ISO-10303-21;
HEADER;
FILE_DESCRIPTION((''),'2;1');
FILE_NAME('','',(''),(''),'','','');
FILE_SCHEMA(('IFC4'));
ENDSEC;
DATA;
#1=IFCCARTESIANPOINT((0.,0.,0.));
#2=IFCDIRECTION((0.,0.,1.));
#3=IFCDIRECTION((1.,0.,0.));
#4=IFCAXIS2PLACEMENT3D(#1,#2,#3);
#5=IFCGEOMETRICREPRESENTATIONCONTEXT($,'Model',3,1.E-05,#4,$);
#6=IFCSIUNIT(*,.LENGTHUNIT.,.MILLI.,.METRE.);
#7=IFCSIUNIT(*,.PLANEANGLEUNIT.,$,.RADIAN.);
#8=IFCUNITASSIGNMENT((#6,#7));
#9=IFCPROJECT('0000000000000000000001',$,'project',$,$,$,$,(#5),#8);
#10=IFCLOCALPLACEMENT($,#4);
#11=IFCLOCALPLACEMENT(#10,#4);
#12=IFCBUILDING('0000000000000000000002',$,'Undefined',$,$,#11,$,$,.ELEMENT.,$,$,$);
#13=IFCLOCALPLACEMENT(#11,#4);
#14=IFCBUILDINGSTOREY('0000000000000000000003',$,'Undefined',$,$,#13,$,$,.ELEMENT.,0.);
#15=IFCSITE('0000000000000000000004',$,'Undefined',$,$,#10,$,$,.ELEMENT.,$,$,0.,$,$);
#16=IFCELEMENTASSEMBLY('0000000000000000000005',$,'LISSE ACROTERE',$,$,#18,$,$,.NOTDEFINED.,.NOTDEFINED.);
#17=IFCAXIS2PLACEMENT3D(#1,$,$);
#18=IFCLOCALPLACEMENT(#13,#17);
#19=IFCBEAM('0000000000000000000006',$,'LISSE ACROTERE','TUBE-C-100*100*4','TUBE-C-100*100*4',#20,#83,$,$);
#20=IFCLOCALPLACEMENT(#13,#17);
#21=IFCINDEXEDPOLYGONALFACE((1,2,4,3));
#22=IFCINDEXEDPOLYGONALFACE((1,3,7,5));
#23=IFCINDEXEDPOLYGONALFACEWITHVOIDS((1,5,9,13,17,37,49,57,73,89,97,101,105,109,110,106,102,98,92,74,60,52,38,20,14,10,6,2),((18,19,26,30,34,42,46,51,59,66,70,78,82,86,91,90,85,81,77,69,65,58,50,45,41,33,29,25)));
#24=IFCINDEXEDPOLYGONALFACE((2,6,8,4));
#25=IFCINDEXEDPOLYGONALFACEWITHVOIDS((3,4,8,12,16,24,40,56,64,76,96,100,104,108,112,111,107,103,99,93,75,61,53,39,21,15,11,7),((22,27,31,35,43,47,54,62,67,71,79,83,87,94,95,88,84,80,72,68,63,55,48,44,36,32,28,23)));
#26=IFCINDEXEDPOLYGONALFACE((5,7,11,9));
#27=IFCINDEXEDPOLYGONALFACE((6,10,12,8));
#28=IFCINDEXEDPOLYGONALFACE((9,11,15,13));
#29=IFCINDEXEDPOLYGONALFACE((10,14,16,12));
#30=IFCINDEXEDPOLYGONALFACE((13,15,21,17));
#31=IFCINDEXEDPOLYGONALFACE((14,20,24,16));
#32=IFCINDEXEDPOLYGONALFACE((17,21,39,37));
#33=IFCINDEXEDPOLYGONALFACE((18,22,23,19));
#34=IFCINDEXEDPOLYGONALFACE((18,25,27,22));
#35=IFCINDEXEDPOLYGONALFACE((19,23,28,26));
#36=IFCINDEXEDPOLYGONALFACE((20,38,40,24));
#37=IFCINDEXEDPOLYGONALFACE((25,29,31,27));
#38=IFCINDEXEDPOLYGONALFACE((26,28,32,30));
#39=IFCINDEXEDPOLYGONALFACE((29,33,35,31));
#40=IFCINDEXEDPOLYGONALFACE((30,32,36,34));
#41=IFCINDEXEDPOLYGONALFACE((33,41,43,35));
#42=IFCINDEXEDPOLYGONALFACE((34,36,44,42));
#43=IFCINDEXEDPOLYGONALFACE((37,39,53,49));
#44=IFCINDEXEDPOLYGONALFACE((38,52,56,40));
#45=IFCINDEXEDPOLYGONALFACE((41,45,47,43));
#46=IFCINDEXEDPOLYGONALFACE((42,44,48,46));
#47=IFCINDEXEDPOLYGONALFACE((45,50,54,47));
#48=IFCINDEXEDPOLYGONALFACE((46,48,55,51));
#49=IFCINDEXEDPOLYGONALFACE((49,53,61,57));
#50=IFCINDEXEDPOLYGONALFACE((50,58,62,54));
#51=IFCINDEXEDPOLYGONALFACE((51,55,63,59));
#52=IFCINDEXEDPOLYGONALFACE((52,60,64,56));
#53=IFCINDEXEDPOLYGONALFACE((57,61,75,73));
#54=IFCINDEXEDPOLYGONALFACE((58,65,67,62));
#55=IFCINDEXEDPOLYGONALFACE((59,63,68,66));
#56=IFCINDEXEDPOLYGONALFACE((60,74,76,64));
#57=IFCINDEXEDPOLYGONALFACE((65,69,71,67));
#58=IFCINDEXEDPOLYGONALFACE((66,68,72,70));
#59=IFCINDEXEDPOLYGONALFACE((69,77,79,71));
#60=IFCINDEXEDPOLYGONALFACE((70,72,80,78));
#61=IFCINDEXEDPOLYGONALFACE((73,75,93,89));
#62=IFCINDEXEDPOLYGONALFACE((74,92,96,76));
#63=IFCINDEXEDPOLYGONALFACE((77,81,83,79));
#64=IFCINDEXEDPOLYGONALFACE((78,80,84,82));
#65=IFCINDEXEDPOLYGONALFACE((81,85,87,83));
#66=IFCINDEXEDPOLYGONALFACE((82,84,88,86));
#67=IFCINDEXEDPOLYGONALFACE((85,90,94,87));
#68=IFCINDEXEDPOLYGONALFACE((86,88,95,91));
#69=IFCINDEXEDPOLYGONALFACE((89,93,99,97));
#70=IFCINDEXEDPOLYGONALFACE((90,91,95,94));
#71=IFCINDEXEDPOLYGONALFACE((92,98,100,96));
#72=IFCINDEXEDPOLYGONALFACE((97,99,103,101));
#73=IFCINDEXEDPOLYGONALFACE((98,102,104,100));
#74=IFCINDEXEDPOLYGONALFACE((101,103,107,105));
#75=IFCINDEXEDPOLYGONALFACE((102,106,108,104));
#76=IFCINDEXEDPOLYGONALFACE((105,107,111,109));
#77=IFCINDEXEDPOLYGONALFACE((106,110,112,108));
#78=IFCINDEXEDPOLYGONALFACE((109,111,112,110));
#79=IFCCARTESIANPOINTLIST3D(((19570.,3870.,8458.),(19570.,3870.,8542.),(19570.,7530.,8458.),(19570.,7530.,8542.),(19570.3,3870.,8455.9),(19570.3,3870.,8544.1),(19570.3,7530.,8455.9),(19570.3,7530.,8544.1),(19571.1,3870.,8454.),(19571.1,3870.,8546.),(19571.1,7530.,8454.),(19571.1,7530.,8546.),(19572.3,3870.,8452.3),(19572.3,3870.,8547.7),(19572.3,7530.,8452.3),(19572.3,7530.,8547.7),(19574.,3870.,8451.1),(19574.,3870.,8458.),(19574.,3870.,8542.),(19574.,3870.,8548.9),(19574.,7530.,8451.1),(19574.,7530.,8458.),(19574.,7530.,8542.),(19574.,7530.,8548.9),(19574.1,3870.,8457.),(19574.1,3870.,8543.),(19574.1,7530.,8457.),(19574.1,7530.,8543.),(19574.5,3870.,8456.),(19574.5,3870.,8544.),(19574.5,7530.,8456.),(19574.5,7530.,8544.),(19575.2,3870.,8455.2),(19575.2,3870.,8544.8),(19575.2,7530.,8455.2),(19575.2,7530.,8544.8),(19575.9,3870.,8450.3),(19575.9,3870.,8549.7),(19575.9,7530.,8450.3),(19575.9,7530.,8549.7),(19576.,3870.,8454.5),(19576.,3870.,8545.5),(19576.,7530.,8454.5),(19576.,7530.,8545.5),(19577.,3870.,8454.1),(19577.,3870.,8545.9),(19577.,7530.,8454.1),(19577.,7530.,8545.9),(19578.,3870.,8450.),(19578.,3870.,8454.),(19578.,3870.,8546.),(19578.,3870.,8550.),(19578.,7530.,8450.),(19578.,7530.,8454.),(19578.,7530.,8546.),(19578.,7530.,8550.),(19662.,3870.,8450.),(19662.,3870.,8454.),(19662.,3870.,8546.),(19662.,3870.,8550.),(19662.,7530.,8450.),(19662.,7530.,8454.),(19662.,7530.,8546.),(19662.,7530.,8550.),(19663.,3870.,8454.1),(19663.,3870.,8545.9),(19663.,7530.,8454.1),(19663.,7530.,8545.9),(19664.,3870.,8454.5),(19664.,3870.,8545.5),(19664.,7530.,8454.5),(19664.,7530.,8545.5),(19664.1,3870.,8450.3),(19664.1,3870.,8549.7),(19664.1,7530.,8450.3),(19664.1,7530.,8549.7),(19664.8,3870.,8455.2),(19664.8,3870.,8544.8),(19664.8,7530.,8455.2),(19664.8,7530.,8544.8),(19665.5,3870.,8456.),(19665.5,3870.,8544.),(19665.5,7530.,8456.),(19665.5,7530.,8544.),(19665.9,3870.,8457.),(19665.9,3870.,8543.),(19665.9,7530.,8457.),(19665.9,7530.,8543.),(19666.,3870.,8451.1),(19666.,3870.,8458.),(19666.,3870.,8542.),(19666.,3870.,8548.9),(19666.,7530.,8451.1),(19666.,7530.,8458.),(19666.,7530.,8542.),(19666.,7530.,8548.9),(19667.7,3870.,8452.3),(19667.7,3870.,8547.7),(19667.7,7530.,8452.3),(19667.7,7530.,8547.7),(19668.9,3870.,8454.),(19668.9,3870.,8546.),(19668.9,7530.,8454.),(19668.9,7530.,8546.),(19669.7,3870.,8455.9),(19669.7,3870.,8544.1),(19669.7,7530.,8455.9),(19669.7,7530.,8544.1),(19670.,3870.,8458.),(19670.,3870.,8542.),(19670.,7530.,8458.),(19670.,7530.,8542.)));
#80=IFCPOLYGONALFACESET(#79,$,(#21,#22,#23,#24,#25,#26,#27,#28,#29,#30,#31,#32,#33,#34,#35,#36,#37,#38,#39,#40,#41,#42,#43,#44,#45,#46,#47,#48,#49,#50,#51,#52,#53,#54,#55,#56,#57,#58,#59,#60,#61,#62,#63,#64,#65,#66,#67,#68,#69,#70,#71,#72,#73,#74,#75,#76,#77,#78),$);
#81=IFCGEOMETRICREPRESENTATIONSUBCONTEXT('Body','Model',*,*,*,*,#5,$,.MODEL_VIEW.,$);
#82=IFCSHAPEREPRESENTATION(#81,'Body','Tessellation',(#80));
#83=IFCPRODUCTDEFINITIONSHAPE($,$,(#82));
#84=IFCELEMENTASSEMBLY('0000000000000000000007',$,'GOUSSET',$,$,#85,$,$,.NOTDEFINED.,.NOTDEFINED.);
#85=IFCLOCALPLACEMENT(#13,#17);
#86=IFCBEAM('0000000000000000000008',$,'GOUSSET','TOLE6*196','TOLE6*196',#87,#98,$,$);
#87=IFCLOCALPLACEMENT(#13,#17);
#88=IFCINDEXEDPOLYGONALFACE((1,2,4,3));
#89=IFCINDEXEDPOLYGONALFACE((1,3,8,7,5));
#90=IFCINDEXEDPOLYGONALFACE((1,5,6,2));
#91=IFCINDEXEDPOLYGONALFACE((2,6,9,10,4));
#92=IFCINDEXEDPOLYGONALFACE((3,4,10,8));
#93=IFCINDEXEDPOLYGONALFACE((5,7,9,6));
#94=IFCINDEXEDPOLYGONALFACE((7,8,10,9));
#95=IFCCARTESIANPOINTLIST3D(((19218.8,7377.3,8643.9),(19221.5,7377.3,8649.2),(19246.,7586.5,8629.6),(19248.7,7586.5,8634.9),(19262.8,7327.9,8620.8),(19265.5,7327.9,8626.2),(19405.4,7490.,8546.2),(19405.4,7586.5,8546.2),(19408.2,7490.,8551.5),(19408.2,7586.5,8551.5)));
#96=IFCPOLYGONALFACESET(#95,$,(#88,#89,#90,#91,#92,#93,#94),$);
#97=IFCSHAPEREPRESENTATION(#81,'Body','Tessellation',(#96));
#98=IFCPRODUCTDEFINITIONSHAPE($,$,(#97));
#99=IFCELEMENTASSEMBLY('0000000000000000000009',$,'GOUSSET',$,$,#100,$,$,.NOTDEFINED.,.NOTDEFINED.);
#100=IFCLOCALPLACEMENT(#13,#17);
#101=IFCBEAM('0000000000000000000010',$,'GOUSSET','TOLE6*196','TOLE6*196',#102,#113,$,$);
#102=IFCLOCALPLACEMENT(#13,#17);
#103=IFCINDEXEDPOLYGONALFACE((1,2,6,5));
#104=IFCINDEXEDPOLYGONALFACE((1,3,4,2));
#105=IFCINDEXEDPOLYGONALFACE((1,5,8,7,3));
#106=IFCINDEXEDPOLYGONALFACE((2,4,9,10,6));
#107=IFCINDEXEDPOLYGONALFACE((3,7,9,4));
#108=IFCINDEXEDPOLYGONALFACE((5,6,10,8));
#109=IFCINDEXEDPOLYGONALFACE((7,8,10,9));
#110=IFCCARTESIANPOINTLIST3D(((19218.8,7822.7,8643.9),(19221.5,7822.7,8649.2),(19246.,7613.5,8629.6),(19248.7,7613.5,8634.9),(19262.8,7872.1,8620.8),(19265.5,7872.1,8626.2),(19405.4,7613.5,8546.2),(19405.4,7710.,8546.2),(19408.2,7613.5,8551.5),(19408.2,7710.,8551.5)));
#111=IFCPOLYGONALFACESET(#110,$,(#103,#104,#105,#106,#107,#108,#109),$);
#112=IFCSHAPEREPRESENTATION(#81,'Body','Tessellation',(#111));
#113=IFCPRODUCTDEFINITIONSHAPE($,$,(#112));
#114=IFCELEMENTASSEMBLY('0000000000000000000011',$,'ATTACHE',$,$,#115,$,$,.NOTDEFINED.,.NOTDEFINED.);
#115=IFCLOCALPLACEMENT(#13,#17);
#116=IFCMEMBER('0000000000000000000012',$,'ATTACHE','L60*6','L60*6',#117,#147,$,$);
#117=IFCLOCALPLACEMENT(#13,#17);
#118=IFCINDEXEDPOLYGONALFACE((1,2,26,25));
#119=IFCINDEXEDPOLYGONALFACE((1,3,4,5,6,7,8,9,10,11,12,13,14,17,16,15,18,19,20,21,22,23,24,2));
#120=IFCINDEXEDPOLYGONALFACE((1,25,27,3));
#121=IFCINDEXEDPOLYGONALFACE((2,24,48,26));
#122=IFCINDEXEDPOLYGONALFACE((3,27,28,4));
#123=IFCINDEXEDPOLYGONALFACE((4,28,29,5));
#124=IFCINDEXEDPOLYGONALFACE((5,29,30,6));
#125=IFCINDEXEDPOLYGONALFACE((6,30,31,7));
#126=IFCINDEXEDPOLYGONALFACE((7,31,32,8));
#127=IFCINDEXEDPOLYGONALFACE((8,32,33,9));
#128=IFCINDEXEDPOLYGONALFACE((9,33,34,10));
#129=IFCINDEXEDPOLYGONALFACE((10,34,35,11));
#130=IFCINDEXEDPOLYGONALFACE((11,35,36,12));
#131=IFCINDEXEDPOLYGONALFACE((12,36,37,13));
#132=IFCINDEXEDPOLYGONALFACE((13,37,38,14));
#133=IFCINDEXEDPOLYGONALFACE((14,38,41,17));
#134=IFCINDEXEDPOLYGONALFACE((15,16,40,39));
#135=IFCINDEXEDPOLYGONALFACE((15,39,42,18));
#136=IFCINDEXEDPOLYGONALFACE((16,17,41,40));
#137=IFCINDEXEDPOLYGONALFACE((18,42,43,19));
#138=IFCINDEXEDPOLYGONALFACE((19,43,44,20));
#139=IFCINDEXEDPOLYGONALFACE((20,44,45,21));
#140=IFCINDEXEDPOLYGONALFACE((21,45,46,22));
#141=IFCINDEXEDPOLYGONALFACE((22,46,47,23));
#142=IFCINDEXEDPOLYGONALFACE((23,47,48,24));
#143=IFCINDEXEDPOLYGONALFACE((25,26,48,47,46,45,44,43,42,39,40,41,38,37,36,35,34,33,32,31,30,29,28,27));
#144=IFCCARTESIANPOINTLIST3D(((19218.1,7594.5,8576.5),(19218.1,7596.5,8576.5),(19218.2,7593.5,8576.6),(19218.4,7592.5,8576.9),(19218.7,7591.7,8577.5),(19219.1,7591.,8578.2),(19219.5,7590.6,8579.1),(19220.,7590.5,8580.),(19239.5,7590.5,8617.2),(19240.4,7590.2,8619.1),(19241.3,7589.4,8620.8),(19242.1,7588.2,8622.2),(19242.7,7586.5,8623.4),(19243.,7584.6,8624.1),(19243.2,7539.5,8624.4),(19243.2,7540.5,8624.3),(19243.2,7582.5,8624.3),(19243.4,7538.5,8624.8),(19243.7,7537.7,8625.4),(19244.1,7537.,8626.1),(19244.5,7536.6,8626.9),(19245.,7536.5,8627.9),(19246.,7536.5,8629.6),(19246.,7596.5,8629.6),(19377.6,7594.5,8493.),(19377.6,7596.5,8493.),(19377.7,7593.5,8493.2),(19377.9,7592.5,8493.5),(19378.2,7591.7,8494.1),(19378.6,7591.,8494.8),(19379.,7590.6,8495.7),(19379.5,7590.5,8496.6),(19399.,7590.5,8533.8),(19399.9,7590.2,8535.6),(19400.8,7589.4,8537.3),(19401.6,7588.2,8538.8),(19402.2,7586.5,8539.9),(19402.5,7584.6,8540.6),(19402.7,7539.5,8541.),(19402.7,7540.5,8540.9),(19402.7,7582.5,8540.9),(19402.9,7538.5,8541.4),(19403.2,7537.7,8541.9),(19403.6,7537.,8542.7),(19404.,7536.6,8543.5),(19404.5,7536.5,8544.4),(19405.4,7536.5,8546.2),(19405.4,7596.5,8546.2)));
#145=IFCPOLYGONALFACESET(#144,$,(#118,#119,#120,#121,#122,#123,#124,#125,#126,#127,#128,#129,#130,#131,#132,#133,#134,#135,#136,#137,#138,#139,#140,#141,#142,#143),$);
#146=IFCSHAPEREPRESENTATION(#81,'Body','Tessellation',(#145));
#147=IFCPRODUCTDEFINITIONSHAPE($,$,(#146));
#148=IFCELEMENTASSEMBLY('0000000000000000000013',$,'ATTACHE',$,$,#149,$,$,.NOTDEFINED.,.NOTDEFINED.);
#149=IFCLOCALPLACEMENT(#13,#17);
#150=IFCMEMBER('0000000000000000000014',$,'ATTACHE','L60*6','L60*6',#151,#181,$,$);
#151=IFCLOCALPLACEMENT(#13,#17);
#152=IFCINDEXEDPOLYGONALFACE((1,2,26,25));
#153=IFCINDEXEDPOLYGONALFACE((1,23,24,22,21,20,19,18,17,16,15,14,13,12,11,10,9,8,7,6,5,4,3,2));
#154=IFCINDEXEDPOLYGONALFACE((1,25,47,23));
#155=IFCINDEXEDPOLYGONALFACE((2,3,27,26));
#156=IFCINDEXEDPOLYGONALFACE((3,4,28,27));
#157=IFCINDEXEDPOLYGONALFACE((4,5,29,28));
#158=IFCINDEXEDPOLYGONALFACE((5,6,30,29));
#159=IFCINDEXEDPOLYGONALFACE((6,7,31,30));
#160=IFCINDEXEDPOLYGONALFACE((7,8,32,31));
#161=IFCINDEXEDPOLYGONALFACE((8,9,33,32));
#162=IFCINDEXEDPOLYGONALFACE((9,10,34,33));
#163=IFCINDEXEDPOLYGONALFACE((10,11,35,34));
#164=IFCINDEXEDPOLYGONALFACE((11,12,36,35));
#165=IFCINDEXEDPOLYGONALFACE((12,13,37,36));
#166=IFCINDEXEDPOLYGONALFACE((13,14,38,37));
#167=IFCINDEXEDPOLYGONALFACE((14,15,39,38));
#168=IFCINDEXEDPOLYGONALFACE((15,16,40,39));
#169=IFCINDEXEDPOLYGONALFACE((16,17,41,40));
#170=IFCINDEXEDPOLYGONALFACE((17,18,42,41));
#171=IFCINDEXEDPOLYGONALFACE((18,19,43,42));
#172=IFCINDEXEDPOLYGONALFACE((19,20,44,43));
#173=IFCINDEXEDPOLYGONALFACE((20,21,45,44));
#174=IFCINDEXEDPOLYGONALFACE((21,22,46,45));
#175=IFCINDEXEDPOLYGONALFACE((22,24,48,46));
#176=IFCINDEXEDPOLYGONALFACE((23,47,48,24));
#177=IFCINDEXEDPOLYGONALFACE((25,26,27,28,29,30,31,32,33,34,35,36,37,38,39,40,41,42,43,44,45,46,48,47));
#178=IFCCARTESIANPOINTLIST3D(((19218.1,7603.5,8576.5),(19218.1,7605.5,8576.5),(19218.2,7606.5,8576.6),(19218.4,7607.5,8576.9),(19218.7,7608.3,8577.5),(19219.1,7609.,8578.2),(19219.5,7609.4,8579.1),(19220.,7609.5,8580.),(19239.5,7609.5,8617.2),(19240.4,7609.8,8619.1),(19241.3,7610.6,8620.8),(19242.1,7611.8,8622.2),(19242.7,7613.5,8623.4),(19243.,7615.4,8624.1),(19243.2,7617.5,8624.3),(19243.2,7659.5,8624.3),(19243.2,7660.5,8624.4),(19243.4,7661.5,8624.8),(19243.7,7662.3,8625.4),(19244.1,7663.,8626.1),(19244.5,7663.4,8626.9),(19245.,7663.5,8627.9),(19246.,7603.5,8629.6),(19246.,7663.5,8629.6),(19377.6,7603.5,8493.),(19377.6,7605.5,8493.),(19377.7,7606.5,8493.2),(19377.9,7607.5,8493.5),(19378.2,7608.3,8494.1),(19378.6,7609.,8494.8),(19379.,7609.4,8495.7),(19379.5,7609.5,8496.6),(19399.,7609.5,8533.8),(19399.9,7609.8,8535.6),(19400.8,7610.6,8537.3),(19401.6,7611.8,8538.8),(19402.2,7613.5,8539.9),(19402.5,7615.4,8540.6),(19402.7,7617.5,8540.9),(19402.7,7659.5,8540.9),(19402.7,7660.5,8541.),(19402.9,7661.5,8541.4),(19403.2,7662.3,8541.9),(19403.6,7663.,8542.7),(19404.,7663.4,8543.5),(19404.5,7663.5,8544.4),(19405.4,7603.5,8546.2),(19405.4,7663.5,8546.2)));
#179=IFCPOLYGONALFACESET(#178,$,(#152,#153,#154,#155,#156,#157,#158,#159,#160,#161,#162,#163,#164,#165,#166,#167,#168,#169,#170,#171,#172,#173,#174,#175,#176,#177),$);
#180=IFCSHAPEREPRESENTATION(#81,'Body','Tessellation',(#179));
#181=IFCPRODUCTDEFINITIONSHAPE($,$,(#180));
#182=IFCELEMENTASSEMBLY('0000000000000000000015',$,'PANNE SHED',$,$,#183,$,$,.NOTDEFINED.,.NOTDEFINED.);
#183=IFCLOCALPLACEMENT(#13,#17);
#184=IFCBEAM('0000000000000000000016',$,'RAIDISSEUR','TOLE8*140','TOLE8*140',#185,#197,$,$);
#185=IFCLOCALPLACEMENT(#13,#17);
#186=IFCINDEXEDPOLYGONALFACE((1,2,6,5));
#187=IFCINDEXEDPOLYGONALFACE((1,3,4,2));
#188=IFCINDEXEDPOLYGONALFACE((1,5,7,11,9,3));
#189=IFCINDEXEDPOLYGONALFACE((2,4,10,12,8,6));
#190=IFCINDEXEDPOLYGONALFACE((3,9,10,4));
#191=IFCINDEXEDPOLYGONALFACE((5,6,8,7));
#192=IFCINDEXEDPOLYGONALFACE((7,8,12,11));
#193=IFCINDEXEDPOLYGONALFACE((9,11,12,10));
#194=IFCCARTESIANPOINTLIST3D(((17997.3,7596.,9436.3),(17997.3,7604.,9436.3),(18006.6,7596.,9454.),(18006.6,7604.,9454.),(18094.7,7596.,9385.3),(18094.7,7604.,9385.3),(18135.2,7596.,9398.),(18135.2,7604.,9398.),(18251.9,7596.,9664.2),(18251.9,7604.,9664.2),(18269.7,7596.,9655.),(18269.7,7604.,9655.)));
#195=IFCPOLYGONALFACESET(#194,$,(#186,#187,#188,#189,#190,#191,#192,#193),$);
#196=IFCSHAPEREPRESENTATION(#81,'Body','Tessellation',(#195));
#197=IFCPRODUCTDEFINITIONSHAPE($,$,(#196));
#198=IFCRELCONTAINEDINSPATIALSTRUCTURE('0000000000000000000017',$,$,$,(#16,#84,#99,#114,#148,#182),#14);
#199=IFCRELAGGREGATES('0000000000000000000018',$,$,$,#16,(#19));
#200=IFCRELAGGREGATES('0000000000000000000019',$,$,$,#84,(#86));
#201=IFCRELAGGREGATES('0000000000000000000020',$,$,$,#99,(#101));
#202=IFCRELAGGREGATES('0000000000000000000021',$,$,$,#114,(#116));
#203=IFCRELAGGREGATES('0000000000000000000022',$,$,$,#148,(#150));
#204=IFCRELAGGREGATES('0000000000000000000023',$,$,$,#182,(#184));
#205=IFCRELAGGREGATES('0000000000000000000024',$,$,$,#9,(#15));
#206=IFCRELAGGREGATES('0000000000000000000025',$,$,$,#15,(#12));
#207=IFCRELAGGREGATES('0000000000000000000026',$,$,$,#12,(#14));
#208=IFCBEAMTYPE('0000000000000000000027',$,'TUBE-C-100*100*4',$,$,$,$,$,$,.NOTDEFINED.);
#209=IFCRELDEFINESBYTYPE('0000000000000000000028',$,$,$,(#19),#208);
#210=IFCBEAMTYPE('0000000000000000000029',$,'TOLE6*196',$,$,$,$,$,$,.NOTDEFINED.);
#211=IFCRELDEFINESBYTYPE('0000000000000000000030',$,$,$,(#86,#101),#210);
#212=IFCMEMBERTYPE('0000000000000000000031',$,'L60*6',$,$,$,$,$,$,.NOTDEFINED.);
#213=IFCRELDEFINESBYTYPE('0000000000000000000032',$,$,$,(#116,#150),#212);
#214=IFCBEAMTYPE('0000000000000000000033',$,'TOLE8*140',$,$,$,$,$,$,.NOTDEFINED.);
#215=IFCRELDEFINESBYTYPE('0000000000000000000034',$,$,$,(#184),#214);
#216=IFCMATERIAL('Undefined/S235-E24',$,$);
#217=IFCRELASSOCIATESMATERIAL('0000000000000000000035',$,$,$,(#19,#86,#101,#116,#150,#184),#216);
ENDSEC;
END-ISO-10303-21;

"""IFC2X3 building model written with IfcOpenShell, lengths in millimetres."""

from ifc_helpers import new_model, si_unit, frame, origin_with_axes, origin_2d_with_axis, place, context, subcontext, project, spatial, polyline, hollow_rectangle, l_section, outline, extrude, material, type_object, element, aggregate, save


model = new_model("IFC2X3")

# Units and contexts
model_context = context("Model", 3, precision=1e-05, world=origin_with_axes())
body_context = subcontext(model_context, "Body", "Model", "MODEL_VIEW")
ifc_project = project(units=[si_unit("LENGTHUNIT", "METRE", prefix="MILLI"), si_unit("PLANEANGLEUNIT", "RADIAN")], contexts=[model_context])

# Site, building, storey
site_placement = place(None, origin_with_axes())
site = spatial("IfcSite", under=ifc_project, at=site_placement, Name="Undefined", CompositionType="ELEMENT", RefElevation=0.0)
building_placement = place(site_placement, origin_with_axes())
building = spatial("IfcBuilding", under=site, at=building_placement, Name="Undefined", CompositionType="ELEMENT")
storey_placement = place(building_placement, origin_with_axes())
storey = spatial("IfcBuildingStorey", under=building, at=storey_placement, Name="Undefined", CompositionType="ELEMENT", Elevation=0.0)

# Element assemblies, beams
ifc_material_1 = material(Name="Undefined/S235-E24")
assembly_1_placement = place(storey_placement, origin_with_axes())
assembly_1 = element("IfcElementAssembly", 1, at=assembly_1_placement, inside=storey, Name="LISSE ACROTERE", AssemblyPlace="NOTDEFINED", PredefinedType="NOTDEFINED")
beam_type_1 = type_object("IfcBeamType", Name="TUBE-C-100*100*4", PredefinedType="NOTDEFINED")
beam_1_placement = place(assembly_1_placement, frame((19620.0, 3870.0, 8500.0), z_axis=(0.0, 0.0, 1.0), x_axis=(0.0, 1.0, 0.0)))
beam_1 = element("IfcBeam", 2, at=beam_1_placement, type_object=beam_type_1, material=ifc_material_1, Name="LISSE ACROTERE", Description="TUBE-C-100*100*4", ObjectType="TUBE-C-100*100*4", context=body_context, shape_type="SweptSolid", body=[
    extrude(hollow_rectangle(XDim=100.0, YDim=100.0, WallThickness=4.0, InnerFilletRadius=4.0, OuterFilletRadius=8.0, at=origin_2d_with_axis()), frame((3660.0, 0.0, 0.0), z_axis=(-1.0, 0.0, 0.0), x_axis=(0.0, -1.0, 0.0)), (0.0, 0.0, 1.0), 3660.0),
])
aggregate(assembly_1, [beam_1])
assembly_2_placement = place(storey_placement, origin_with_axes())
assembly_2 = element("IfcElementAssembly", 3, at=assembly_2_placement, inside=storey, Name="GOUSSET", AssemblyPlace="NOTDEFINED", PredefinedType="NOTDEFINED")
beam_type_2 = type_object("IfcBeamType", Name="TOLE6*196", PredefinedType="NOTDEFINED")
beam_2_placement = place(assembly_2_placement, frame((19406.8, 7490.0, 8548.9), z_axis=(0.463529, 0.0, 0.886082), x_axis=(0.0, 1.0, 0.0)))
beam_2 = element("IfcBeam", 4, at=beam_2_placement, type_object=beam_type_2, material=ifc_material_1, Name="GOUSSET", Description="TOLE6*196", ObjectType="TOLE6*196", context=body_context, shape_type="SweptSolid", body=[
    extrude(outline(polyline([(0.0, 0.0), (96.5, 0.0), (96.5, 180.0), (-112.7, 210.7), (-162.0, 161.0), (0.0, 0.0)])), frame((0.0, 0.0, -3.0), z_axis=(0.0, 0.0, 1.0), x_axis=(1.0, 0.0, 0.0)), (0.0, 0.0, 1.0), 6.0),
])
aggregate(assembly_2, [beam_2])
assembly_3_placement = place(storey_placement, origin_with_axes())
assembly_3 = element("IfcElementAssembly", 5, at=assembly_3_placement, inside=storey, Name="GOUSSET", AssemblyPlace="NOTDEFINED", PredefinedType="NOTDEFINED")
beam_3_placement = place(assembly_3_placement, frame((19406.8, 7613.5, 8548.9), z_axis=(0.463529, 0.0, 0.886082), x_axis=(0.0, 1.0, 0.0)))
beam_3 = element("IfcBeam", 6, at=beam_3_placement, type_object=beam_type_2, material=ifc_material_1, Name="GOUSSET", Description="TOLE6*196", ObjectType="TOLE6*196", context=body_context, shape_type="SweptSolid", body=[
    extrude(outline(polyline([(0.0, 0.0), (96.5, 0.0), (258.6, 161.0), (209.2, 210.7), (0.0, 180.0), (0.0, 0.0)])), frame((0.0, 0.0, -3.0), z_axis=(0.0, 0.0, 1.0), x_axis=(1.0, 0.0, 0.0)), (0.0, 0.0, 1.0), 6.0),
])
aggregate(assembly_3, [beam_3])

# Element assemblies, members
assembly_4_placement = place(storey_placement, origin_with_axes())
assembly_4 = element("IfcElementAssembly", 7, at=assembly_4_placement, inside=storey, Name="ATTACHE", AssemblyPlace="NOTDEFINED", PredefinedType="NOTDEFINED")
member_type = type_object("IfcMemberType", Name="L60*6", PredefinedType="NOTDEFINED")
member_1_placement = place(assembly_4_placement, frame((19232.0, 7566.5, 8603.0), z_axis=(0.0, -1.0, 0.0), x_axis=(0.886082, 0.0, -0.463529)))
member_1 = element("IfcMember", 8, at=member_1_placement, type_object=member_type, material=ifc_material_1, Name="ATTACHE", Description="L60*6", ObjectType="L60*6", context=body_context, shape_type="SweptSolid", body=[
    extrude(l_section(Depth=60.0, Width=60.0, Thickness=6.0, FilletRadius=8.0, EdgeRadius=4.0, at=origin_2d_with_axis()), frame((180.0, 0.0, 0.0), z_axis=(-1.0, 0.0, 0.0), x_axis=(0.0, -1.0, 0.0)), (0.0, 0.0, 1.0), 180.0),
])
aggregate(assembly_4, [member_1])
assembly_5_placement = place(storey_placement, origin_with_axes())
assembly_5 = element("IfcElementAssembly", 9, at=assembly_5_placement, inside=storey, Name="ATTACHE", AssemblyPlace="NOTDEFINED", PredefinedType="NOTDEFINED")
member_2_placement = place(assembly_5_placement, frame((19391.5, 7633.5, 8519.6), z_axis=(0.0, 1.0, 0.0), x_axis=(-0.886082, 0.0, 0.463529)))
member_2 = element("IfcMember", 10, at=member_2_placement, type_object=member_type, material=ifc_material_1, Name="ATTACHE", Description="L60*6", ObjectType="L60*6", context=body_context, shape_type="SweptSolid", body=[
    extrude(l_section(Depth=60.0, Width=60.0, Thickness=6.0, FilletRadius=8.0, EdgeRadius=4.0, at=origin_2d_with_axis()), frame((180.0, 0.0, 0.0), z_axis=(-1.0, 0.0, 0.0), x_axis=(0.0, -1.0, 0.0)), (0.0, 0.0, 1.0), 180.0),
])
aggregate(assembly_5, [member_2])

# Element assembly, beam
assembly_6_placement = place(storey_placement, origin_with_axes())
assembly_6 = element("IfcElementAssembly", 11, at=assembly_6_placement, inside=storey, Name="PANNE SHED", AssemblyPlace="NOTDEFINED", PredefinedType="NOTDEFINED")
beam_type_3 = type_object("IfcBeamType", Name="TOLE8*140", PredefinedType="NOTDEFINED")
beam_4_placement = place(assembly_6_placement, frame((18269.7, 7600.0, 9655.0), z_axis=(0.0, -1.0, 0.0), x_axis=(-0.886082, 0.0, 0.463529)))
beam_4 = element("IfcBeam", 12, at=beam_4_placement, type_object=beam_type_3, material=ifc_material_1, Name="RAIDISSEUR", Description="TOLE8*140", ObjectType="TOLE8*140", context=body_context, shape_type="SweptSolid", body=[
    extrude(outline(polyline([(0.0, 0.0), (20.0, 0.0), (140.0, 300.0), (140.0, 320.0), (30.0, 320.0), (0.0, 290.0), (0.0, 0.0)])), frame((0.0, 0.0, -4.0), z_axis=(0.0, 0.0, 1.0), x_axis=(1.0, 0.0, 0.0)), (0.0, 0.0, 1.0), 8.0),
])
aggregate(assembly_6, [beam_4])

save(model, "model.ifc")
